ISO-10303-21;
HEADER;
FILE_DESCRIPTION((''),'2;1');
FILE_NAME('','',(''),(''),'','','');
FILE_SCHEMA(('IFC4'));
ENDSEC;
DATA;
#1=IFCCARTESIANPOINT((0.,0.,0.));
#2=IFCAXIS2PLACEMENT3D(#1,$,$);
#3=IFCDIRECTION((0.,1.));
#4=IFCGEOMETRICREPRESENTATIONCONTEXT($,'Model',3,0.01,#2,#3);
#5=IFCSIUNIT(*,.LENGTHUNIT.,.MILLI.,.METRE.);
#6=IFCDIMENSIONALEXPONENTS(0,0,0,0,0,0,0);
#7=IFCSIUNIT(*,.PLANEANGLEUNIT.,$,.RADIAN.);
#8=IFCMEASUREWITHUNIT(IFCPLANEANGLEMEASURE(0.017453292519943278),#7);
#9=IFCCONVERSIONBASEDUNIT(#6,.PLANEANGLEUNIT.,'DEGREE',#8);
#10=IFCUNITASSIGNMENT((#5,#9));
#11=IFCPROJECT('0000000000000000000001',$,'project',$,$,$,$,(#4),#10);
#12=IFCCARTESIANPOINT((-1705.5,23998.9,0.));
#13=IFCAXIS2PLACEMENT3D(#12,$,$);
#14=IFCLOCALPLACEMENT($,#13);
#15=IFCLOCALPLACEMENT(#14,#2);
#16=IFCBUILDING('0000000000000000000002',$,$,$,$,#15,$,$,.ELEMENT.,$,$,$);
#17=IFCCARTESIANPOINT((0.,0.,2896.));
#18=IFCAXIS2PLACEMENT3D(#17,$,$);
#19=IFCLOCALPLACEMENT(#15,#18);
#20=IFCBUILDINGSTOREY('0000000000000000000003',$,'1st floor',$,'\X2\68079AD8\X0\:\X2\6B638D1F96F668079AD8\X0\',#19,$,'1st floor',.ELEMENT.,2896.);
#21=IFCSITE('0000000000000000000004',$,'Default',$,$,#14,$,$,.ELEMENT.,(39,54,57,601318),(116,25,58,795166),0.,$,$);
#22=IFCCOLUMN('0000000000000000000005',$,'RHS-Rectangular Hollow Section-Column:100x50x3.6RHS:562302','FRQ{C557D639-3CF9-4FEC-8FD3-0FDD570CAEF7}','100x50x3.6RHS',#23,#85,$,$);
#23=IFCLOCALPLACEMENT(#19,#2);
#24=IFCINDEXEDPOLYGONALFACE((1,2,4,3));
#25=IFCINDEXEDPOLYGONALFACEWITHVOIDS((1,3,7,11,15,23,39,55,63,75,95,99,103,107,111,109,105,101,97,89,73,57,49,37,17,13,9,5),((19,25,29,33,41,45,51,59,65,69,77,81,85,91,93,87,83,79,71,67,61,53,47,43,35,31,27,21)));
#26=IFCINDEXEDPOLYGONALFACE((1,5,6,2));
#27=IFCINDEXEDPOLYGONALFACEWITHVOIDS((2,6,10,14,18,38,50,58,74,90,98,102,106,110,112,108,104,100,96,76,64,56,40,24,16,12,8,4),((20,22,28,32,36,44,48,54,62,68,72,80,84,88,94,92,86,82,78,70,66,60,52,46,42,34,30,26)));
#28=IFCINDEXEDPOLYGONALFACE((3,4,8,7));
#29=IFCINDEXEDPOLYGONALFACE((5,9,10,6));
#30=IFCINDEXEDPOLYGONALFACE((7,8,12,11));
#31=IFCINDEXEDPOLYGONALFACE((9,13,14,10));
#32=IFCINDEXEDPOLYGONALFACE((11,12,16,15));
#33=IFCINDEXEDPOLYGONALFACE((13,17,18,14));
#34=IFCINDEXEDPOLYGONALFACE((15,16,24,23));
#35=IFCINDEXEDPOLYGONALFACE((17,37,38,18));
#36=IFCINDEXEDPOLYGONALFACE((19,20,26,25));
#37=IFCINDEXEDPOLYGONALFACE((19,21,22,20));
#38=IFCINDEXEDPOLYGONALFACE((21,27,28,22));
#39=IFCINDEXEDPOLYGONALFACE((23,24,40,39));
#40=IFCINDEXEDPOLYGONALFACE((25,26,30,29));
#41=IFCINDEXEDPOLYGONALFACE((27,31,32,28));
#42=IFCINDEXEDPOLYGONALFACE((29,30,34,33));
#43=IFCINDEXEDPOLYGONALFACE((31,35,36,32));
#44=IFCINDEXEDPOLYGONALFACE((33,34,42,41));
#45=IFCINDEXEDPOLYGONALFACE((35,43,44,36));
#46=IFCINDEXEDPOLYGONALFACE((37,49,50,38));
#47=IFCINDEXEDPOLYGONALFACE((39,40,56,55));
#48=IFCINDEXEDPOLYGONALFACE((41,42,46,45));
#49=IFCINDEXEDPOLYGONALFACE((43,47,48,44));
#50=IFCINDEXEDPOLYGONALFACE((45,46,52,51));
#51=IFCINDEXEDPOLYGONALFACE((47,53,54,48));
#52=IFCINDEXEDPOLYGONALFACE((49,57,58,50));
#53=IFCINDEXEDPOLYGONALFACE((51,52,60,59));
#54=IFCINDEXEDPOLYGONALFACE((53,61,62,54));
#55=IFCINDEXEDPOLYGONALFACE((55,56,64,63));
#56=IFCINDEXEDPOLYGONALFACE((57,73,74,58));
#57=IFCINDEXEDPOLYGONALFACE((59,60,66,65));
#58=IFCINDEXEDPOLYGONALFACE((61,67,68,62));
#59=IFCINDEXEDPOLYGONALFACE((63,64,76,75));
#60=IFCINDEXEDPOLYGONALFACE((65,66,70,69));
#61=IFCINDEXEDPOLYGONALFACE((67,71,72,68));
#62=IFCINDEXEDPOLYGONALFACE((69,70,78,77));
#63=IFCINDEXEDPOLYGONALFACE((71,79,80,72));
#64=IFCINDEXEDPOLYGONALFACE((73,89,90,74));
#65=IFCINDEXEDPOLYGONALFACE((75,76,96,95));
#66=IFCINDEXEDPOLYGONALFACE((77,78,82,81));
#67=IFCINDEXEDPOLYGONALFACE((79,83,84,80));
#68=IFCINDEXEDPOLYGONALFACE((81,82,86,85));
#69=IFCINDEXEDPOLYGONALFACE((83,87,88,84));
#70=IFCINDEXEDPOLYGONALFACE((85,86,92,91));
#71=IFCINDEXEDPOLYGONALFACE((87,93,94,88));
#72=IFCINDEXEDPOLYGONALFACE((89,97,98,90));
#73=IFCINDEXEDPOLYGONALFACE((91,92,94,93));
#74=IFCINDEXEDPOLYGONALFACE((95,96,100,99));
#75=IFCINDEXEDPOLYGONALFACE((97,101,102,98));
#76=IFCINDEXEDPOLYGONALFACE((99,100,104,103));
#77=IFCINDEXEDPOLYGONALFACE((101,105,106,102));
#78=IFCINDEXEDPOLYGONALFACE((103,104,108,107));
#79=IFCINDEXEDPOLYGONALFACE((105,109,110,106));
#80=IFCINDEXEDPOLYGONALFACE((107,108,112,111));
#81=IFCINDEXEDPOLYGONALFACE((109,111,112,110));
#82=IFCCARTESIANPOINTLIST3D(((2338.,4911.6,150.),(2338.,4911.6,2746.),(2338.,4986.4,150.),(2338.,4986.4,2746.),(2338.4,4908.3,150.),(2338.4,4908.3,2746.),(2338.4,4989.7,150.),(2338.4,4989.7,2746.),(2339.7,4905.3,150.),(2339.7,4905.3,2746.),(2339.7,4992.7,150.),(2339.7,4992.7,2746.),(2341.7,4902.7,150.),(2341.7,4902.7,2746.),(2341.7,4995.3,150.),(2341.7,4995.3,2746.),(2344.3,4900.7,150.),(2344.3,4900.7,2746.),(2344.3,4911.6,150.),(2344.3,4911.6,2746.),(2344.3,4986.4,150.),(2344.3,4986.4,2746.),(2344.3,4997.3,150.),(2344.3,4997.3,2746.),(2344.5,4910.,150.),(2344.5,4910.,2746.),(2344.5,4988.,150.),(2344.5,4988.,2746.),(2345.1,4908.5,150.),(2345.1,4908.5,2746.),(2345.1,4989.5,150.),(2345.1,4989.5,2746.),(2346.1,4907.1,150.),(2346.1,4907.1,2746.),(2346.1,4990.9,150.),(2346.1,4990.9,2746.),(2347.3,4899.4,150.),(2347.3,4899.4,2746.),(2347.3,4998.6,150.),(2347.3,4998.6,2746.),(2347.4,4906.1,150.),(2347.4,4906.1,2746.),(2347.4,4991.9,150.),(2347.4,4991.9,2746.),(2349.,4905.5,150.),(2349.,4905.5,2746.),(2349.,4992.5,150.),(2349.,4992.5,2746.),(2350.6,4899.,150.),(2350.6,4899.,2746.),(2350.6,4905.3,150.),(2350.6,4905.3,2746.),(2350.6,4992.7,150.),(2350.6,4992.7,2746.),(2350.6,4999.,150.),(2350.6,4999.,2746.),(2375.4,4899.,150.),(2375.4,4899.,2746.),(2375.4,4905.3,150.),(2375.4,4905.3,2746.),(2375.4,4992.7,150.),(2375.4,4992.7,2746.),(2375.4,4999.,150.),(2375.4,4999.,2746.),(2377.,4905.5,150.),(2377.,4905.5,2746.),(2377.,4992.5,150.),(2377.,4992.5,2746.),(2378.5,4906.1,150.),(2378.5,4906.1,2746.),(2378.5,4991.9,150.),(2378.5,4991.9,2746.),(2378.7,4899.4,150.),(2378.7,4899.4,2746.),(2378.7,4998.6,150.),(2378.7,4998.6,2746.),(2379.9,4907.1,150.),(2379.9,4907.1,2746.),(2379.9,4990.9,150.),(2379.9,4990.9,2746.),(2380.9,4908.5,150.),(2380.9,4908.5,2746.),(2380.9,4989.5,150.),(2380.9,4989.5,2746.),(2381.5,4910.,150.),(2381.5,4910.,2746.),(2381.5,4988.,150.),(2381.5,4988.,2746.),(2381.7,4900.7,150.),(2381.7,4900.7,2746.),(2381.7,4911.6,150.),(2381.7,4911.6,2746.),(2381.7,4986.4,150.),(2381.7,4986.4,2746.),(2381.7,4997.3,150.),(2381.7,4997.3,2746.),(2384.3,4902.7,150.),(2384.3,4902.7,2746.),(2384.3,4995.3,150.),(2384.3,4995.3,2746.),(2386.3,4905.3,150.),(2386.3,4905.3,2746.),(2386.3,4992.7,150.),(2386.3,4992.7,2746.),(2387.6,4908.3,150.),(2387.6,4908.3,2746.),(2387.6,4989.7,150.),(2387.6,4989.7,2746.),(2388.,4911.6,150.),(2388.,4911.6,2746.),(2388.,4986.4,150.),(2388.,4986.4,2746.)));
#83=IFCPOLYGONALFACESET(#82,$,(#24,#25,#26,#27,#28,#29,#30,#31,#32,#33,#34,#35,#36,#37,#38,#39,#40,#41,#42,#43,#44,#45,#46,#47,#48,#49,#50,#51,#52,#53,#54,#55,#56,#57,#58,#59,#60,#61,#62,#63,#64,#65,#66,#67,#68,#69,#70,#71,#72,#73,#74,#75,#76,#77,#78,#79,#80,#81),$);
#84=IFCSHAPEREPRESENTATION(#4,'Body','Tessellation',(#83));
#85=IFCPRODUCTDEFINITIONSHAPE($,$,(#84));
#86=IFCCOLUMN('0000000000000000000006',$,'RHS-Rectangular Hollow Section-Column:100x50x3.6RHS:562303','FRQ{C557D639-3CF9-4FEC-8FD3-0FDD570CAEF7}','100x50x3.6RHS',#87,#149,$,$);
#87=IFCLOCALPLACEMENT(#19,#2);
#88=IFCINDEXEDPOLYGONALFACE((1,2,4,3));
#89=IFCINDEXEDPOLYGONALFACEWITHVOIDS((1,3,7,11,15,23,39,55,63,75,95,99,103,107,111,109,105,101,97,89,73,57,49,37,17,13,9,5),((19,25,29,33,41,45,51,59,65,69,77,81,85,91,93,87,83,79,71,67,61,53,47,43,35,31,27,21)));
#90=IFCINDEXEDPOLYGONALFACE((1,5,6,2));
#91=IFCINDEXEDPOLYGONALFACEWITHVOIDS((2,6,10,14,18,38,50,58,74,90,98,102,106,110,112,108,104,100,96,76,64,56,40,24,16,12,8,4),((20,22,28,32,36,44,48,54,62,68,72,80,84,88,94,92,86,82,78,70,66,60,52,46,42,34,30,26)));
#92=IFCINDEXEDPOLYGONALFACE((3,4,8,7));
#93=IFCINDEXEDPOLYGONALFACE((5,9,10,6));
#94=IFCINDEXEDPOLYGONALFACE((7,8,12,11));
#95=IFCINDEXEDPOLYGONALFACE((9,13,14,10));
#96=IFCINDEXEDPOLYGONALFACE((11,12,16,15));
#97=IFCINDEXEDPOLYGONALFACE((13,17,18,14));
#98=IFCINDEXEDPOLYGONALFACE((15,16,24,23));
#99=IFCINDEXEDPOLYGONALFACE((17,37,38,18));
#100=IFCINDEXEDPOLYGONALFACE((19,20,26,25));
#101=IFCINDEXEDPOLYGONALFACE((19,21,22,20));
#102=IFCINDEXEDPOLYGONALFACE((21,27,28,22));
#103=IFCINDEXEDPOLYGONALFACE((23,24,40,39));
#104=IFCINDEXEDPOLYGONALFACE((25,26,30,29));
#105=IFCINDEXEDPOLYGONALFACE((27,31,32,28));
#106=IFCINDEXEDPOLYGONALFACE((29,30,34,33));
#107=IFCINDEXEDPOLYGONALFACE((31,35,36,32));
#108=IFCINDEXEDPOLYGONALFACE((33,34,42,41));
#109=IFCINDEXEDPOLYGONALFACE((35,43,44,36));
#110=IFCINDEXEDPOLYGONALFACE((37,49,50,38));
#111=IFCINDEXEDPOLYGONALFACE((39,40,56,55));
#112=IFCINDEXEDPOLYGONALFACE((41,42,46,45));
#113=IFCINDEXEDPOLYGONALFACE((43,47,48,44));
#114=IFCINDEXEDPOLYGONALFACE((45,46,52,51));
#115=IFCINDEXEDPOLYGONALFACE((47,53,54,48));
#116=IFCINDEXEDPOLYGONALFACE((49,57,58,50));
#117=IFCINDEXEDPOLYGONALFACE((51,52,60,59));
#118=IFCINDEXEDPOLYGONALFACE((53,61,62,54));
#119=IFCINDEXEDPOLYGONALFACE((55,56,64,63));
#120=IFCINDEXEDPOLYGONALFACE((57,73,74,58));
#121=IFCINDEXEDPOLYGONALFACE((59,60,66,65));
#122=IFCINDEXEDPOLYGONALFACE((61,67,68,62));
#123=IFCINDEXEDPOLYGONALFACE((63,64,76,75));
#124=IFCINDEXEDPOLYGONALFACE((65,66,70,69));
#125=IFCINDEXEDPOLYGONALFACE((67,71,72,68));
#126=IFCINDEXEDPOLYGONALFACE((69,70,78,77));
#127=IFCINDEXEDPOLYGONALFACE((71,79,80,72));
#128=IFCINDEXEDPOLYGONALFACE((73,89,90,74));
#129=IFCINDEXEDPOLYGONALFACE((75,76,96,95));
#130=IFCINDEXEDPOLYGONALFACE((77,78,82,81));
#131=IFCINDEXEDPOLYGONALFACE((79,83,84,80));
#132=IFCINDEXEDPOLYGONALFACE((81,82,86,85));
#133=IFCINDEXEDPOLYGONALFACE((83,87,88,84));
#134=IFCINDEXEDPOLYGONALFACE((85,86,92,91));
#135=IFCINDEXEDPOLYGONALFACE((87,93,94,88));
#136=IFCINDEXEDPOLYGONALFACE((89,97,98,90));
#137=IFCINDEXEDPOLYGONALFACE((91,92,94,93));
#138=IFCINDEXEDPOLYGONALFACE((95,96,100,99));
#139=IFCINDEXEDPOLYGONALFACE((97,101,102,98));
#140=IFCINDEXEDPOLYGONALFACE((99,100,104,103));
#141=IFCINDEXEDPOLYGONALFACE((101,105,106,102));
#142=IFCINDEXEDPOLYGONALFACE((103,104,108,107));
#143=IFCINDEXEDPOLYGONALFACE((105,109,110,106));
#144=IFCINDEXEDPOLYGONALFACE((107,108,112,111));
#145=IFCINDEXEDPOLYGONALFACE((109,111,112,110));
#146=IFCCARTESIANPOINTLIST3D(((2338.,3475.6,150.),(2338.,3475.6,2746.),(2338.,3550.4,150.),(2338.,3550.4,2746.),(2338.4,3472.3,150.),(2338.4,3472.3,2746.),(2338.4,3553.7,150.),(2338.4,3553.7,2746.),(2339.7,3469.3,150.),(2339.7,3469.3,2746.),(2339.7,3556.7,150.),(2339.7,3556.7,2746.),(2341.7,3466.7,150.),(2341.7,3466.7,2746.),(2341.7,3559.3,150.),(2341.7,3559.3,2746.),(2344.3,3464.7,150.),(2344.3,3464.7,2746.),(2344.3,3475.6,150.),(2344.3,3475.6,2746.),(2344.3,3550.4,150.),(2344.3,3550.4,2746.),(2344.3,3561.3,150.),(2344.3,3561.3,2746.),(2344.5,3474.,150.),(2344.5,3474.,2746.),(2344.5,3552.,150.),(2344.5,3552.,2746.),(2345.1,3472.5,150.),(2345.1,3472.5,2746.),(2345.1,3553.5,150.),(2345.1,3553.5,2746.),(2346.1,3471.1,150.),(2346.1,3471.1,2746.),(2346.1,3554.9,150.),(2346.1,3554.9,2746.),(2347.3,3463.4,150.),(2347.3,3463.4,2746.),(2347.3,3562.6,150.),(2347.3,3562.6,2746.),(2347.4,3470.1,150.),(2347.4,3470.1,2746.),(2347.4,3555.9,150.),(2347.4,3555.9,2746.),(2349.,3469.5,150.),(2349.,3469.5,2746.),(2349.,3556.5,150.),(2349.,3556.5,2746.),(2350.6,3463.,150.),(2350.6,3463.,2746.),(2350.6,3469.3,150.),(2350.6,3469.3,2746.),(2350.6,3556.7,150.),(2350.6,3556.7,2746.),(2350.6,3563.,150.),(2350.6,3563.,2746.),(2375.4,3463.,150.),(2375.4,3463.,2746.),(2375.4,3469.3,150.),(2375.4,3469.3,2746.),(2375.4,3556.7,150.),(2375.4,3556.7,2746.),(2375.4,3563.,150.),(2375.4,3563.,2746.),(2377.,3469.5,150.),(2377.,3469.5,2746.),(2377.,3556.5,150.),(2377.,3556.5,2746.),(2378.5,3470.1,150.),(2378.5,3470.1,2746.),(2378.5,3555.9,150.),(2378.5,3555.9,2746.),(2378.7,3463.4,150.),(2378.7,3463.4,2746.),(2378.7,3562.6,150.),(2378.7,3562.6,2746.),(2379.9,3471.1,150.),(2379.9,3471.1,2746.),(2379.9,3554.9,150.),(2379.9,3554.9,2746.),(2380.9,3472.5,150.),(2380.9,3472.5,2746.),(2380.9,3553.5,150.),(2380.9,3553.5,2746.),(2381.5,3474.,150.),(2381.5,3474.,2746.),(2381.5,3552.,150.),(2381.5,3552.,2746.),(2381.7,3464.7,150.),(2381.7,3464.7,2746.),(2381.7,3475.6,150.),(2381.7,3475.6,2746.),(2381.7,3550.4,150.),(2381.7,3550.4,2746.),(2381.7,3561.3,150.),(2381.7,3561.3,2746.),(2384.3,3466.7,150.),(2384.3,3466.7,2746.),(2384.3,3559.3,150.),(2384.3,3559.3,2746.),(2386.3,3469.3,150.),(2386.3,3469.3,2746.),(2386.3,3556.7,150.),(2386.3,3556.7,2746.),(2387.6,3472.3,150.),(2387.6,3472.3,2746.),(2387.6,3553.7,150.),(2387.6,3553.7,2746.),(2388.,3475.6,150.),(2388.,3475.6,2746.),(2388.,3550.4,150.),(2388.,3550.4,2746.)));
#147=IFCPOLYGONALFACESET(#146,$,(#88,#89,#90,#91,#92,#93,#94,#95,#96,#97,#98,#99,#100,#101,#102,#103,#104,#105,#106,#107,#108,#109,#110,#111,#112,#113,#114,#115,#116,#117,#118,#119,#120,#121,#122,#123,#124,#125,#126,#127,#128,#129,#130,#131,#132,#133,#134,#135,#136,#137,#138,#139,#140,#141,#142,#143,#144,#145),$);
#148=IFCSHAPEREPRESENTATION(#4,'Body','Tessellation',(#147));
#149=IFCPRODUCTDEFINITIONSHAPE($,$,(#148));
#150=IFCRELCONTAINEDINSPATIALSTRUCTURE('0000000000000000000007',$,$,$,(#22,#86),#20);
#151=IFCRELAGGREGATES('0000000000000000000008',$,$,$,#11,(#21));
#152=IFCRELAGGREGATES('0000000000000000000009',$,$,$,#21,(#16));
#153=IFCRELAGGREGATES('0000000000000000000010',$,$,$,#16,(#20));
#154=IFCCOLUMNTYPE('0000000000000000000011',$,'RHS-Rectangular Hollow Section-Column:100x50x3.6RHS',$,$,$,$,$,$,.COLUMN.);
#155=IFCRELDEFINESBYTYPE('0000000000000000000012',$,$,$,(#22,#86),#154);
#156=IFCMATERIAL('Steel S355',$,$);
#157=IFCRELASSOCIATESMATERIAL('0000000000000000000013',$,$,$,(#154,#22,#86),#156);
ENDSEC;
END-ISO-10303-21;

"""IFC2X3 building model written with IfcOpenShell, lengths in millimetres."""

from ifc_helpers import new_model, entity, si_unit, converted_unit, direction, frame, origin, origin_2d, place, context, project, spatial, hollow_rectangle, extrude, clip, halfspace, material, type_object, element, save


model = new_model("IFC2X3")

# Units and contexts
model_context = context("Model", 3, precision=0.01, world=origin(), true_north=direction((0.0, 1.0)))
ifc_project = project(units=[si_unit("LENGTHUNIT", "METRE", prefix="MILLI"), converted_unit("PLANEANGLEUNIT", "DEGREE", entity("IfcPlaneAngleMeasure", 0.017453292519943278), si_unit("PLANEANGLEUNIT", "RADIAN"), dimensions=[0, 0, 0, 0, 0, 0, 0])], contexts=[model_context])

# Site, building, storey
site_placement = place(None, frame((-1705.5, 23998.9, 0.0)))
site = spatial("IfcSite", under=ifc_project, at=site_placement, Name="Default", CompositionType="ELEMENT", RefLatitude=(39, 54, 57, 601318), RefLongitude=(116, 25, 58, 795166), RefElevation=0.0)
building_placement = place(site_placement, origin())
building = spatial("IfcBuilding", under=site, at=building_placement, CompositionType="ELEMENT")
storey_placement = place(building_placement, frame((0.0, 0.0, 2896.0)))
storey = spatial("IfcBuildingStorey", under=building, at=storey_placement, Name="1st floor", ObjectType="标高:正负零标高", LongName="1st floor", CompositionType="ELEMENT", Elevation=2896.0)

# Shared definitions
ifc_material_1 = material(Name="Steel S355")

# Columns
column_type_1 = type_object("IfcColumnType", Name="RHS-Rectangular Hollow Section-Column:100x50x3.6RHS", PredefinedType="COLUMN", material=ifc_material_1)
column_1_placement = place(storey_placement, frame((2363.0, 4949.0, 2746.0), z_axis=(0.0, 0.0, 1.0), x_axis=(-1.0, 0.0, 0.0)))
element("IfcColumn", 1, at=column_1_placement, inside=storey, type_object=column_type_1, material=ifc_material_1, Name="RHS-Rectangular Hollow Section-Column:100x50x3.6RHS:562302", Description="FRQ{C557D639-3CF9-4FEC-8FD3-0FDD570CAEF7}", ObjectType="100x50x3.6RHS", context=model_context, shape_type="Clipping", body=[
    clip(extrude(hollow_rectangle(XDim=50.0, YDim=100.0, WallThickness=6.3, InnerFilletRadius=6.3, OuterFilletRadius=12.6, at=origin_2d()), origin(), (0.0, 0.0, -1.0), 2651.9), halfspace(frame((2363.0, 4949.0, -2596.0), z_axis=(0.0, 0.0, 1.0), x_axis=(-1.0, 0.0, 0.0)), True)),
])
column_2_placement = place(storey_placement, frame((2363.0, 3513.0, 2746.0), z_axis=(0.0, 0.0, 1.0), x_axis=(-1.0, 0.0, 0.0)))
element("IfcColumn", 2, at=column_2_placement, inside=storey, type_object=column_type_1, material=ifc_material_1, Name="RHS-Rectangular Hollow Section-Column:100x50x3.6RHS:562303", Description="FRQ{C557D639-3CF9-4FEC-8FD3-0FDD570CAEF7}", ObjectType="100x50x3.6RHS", context=model_context, shape_type="Clipping", body=[
    clip(extrude(hollow_rectangle(XDim=50.0, YDim=100.0, WallThickness=6.3, InnerFilletRadius=6.3, OuterFilletRadius=12.6, at=origin_2d()), origin(), (0.0, 0.0, -1.0), 2651.9), halfspace(frame((2363.0, 3513.0, -2596.0), z_axis=(0.0, 0.0, 1.0), x_axis=(-1.0, 0.0, 0.0)), True)),
])

save(model, "model.ifc")
